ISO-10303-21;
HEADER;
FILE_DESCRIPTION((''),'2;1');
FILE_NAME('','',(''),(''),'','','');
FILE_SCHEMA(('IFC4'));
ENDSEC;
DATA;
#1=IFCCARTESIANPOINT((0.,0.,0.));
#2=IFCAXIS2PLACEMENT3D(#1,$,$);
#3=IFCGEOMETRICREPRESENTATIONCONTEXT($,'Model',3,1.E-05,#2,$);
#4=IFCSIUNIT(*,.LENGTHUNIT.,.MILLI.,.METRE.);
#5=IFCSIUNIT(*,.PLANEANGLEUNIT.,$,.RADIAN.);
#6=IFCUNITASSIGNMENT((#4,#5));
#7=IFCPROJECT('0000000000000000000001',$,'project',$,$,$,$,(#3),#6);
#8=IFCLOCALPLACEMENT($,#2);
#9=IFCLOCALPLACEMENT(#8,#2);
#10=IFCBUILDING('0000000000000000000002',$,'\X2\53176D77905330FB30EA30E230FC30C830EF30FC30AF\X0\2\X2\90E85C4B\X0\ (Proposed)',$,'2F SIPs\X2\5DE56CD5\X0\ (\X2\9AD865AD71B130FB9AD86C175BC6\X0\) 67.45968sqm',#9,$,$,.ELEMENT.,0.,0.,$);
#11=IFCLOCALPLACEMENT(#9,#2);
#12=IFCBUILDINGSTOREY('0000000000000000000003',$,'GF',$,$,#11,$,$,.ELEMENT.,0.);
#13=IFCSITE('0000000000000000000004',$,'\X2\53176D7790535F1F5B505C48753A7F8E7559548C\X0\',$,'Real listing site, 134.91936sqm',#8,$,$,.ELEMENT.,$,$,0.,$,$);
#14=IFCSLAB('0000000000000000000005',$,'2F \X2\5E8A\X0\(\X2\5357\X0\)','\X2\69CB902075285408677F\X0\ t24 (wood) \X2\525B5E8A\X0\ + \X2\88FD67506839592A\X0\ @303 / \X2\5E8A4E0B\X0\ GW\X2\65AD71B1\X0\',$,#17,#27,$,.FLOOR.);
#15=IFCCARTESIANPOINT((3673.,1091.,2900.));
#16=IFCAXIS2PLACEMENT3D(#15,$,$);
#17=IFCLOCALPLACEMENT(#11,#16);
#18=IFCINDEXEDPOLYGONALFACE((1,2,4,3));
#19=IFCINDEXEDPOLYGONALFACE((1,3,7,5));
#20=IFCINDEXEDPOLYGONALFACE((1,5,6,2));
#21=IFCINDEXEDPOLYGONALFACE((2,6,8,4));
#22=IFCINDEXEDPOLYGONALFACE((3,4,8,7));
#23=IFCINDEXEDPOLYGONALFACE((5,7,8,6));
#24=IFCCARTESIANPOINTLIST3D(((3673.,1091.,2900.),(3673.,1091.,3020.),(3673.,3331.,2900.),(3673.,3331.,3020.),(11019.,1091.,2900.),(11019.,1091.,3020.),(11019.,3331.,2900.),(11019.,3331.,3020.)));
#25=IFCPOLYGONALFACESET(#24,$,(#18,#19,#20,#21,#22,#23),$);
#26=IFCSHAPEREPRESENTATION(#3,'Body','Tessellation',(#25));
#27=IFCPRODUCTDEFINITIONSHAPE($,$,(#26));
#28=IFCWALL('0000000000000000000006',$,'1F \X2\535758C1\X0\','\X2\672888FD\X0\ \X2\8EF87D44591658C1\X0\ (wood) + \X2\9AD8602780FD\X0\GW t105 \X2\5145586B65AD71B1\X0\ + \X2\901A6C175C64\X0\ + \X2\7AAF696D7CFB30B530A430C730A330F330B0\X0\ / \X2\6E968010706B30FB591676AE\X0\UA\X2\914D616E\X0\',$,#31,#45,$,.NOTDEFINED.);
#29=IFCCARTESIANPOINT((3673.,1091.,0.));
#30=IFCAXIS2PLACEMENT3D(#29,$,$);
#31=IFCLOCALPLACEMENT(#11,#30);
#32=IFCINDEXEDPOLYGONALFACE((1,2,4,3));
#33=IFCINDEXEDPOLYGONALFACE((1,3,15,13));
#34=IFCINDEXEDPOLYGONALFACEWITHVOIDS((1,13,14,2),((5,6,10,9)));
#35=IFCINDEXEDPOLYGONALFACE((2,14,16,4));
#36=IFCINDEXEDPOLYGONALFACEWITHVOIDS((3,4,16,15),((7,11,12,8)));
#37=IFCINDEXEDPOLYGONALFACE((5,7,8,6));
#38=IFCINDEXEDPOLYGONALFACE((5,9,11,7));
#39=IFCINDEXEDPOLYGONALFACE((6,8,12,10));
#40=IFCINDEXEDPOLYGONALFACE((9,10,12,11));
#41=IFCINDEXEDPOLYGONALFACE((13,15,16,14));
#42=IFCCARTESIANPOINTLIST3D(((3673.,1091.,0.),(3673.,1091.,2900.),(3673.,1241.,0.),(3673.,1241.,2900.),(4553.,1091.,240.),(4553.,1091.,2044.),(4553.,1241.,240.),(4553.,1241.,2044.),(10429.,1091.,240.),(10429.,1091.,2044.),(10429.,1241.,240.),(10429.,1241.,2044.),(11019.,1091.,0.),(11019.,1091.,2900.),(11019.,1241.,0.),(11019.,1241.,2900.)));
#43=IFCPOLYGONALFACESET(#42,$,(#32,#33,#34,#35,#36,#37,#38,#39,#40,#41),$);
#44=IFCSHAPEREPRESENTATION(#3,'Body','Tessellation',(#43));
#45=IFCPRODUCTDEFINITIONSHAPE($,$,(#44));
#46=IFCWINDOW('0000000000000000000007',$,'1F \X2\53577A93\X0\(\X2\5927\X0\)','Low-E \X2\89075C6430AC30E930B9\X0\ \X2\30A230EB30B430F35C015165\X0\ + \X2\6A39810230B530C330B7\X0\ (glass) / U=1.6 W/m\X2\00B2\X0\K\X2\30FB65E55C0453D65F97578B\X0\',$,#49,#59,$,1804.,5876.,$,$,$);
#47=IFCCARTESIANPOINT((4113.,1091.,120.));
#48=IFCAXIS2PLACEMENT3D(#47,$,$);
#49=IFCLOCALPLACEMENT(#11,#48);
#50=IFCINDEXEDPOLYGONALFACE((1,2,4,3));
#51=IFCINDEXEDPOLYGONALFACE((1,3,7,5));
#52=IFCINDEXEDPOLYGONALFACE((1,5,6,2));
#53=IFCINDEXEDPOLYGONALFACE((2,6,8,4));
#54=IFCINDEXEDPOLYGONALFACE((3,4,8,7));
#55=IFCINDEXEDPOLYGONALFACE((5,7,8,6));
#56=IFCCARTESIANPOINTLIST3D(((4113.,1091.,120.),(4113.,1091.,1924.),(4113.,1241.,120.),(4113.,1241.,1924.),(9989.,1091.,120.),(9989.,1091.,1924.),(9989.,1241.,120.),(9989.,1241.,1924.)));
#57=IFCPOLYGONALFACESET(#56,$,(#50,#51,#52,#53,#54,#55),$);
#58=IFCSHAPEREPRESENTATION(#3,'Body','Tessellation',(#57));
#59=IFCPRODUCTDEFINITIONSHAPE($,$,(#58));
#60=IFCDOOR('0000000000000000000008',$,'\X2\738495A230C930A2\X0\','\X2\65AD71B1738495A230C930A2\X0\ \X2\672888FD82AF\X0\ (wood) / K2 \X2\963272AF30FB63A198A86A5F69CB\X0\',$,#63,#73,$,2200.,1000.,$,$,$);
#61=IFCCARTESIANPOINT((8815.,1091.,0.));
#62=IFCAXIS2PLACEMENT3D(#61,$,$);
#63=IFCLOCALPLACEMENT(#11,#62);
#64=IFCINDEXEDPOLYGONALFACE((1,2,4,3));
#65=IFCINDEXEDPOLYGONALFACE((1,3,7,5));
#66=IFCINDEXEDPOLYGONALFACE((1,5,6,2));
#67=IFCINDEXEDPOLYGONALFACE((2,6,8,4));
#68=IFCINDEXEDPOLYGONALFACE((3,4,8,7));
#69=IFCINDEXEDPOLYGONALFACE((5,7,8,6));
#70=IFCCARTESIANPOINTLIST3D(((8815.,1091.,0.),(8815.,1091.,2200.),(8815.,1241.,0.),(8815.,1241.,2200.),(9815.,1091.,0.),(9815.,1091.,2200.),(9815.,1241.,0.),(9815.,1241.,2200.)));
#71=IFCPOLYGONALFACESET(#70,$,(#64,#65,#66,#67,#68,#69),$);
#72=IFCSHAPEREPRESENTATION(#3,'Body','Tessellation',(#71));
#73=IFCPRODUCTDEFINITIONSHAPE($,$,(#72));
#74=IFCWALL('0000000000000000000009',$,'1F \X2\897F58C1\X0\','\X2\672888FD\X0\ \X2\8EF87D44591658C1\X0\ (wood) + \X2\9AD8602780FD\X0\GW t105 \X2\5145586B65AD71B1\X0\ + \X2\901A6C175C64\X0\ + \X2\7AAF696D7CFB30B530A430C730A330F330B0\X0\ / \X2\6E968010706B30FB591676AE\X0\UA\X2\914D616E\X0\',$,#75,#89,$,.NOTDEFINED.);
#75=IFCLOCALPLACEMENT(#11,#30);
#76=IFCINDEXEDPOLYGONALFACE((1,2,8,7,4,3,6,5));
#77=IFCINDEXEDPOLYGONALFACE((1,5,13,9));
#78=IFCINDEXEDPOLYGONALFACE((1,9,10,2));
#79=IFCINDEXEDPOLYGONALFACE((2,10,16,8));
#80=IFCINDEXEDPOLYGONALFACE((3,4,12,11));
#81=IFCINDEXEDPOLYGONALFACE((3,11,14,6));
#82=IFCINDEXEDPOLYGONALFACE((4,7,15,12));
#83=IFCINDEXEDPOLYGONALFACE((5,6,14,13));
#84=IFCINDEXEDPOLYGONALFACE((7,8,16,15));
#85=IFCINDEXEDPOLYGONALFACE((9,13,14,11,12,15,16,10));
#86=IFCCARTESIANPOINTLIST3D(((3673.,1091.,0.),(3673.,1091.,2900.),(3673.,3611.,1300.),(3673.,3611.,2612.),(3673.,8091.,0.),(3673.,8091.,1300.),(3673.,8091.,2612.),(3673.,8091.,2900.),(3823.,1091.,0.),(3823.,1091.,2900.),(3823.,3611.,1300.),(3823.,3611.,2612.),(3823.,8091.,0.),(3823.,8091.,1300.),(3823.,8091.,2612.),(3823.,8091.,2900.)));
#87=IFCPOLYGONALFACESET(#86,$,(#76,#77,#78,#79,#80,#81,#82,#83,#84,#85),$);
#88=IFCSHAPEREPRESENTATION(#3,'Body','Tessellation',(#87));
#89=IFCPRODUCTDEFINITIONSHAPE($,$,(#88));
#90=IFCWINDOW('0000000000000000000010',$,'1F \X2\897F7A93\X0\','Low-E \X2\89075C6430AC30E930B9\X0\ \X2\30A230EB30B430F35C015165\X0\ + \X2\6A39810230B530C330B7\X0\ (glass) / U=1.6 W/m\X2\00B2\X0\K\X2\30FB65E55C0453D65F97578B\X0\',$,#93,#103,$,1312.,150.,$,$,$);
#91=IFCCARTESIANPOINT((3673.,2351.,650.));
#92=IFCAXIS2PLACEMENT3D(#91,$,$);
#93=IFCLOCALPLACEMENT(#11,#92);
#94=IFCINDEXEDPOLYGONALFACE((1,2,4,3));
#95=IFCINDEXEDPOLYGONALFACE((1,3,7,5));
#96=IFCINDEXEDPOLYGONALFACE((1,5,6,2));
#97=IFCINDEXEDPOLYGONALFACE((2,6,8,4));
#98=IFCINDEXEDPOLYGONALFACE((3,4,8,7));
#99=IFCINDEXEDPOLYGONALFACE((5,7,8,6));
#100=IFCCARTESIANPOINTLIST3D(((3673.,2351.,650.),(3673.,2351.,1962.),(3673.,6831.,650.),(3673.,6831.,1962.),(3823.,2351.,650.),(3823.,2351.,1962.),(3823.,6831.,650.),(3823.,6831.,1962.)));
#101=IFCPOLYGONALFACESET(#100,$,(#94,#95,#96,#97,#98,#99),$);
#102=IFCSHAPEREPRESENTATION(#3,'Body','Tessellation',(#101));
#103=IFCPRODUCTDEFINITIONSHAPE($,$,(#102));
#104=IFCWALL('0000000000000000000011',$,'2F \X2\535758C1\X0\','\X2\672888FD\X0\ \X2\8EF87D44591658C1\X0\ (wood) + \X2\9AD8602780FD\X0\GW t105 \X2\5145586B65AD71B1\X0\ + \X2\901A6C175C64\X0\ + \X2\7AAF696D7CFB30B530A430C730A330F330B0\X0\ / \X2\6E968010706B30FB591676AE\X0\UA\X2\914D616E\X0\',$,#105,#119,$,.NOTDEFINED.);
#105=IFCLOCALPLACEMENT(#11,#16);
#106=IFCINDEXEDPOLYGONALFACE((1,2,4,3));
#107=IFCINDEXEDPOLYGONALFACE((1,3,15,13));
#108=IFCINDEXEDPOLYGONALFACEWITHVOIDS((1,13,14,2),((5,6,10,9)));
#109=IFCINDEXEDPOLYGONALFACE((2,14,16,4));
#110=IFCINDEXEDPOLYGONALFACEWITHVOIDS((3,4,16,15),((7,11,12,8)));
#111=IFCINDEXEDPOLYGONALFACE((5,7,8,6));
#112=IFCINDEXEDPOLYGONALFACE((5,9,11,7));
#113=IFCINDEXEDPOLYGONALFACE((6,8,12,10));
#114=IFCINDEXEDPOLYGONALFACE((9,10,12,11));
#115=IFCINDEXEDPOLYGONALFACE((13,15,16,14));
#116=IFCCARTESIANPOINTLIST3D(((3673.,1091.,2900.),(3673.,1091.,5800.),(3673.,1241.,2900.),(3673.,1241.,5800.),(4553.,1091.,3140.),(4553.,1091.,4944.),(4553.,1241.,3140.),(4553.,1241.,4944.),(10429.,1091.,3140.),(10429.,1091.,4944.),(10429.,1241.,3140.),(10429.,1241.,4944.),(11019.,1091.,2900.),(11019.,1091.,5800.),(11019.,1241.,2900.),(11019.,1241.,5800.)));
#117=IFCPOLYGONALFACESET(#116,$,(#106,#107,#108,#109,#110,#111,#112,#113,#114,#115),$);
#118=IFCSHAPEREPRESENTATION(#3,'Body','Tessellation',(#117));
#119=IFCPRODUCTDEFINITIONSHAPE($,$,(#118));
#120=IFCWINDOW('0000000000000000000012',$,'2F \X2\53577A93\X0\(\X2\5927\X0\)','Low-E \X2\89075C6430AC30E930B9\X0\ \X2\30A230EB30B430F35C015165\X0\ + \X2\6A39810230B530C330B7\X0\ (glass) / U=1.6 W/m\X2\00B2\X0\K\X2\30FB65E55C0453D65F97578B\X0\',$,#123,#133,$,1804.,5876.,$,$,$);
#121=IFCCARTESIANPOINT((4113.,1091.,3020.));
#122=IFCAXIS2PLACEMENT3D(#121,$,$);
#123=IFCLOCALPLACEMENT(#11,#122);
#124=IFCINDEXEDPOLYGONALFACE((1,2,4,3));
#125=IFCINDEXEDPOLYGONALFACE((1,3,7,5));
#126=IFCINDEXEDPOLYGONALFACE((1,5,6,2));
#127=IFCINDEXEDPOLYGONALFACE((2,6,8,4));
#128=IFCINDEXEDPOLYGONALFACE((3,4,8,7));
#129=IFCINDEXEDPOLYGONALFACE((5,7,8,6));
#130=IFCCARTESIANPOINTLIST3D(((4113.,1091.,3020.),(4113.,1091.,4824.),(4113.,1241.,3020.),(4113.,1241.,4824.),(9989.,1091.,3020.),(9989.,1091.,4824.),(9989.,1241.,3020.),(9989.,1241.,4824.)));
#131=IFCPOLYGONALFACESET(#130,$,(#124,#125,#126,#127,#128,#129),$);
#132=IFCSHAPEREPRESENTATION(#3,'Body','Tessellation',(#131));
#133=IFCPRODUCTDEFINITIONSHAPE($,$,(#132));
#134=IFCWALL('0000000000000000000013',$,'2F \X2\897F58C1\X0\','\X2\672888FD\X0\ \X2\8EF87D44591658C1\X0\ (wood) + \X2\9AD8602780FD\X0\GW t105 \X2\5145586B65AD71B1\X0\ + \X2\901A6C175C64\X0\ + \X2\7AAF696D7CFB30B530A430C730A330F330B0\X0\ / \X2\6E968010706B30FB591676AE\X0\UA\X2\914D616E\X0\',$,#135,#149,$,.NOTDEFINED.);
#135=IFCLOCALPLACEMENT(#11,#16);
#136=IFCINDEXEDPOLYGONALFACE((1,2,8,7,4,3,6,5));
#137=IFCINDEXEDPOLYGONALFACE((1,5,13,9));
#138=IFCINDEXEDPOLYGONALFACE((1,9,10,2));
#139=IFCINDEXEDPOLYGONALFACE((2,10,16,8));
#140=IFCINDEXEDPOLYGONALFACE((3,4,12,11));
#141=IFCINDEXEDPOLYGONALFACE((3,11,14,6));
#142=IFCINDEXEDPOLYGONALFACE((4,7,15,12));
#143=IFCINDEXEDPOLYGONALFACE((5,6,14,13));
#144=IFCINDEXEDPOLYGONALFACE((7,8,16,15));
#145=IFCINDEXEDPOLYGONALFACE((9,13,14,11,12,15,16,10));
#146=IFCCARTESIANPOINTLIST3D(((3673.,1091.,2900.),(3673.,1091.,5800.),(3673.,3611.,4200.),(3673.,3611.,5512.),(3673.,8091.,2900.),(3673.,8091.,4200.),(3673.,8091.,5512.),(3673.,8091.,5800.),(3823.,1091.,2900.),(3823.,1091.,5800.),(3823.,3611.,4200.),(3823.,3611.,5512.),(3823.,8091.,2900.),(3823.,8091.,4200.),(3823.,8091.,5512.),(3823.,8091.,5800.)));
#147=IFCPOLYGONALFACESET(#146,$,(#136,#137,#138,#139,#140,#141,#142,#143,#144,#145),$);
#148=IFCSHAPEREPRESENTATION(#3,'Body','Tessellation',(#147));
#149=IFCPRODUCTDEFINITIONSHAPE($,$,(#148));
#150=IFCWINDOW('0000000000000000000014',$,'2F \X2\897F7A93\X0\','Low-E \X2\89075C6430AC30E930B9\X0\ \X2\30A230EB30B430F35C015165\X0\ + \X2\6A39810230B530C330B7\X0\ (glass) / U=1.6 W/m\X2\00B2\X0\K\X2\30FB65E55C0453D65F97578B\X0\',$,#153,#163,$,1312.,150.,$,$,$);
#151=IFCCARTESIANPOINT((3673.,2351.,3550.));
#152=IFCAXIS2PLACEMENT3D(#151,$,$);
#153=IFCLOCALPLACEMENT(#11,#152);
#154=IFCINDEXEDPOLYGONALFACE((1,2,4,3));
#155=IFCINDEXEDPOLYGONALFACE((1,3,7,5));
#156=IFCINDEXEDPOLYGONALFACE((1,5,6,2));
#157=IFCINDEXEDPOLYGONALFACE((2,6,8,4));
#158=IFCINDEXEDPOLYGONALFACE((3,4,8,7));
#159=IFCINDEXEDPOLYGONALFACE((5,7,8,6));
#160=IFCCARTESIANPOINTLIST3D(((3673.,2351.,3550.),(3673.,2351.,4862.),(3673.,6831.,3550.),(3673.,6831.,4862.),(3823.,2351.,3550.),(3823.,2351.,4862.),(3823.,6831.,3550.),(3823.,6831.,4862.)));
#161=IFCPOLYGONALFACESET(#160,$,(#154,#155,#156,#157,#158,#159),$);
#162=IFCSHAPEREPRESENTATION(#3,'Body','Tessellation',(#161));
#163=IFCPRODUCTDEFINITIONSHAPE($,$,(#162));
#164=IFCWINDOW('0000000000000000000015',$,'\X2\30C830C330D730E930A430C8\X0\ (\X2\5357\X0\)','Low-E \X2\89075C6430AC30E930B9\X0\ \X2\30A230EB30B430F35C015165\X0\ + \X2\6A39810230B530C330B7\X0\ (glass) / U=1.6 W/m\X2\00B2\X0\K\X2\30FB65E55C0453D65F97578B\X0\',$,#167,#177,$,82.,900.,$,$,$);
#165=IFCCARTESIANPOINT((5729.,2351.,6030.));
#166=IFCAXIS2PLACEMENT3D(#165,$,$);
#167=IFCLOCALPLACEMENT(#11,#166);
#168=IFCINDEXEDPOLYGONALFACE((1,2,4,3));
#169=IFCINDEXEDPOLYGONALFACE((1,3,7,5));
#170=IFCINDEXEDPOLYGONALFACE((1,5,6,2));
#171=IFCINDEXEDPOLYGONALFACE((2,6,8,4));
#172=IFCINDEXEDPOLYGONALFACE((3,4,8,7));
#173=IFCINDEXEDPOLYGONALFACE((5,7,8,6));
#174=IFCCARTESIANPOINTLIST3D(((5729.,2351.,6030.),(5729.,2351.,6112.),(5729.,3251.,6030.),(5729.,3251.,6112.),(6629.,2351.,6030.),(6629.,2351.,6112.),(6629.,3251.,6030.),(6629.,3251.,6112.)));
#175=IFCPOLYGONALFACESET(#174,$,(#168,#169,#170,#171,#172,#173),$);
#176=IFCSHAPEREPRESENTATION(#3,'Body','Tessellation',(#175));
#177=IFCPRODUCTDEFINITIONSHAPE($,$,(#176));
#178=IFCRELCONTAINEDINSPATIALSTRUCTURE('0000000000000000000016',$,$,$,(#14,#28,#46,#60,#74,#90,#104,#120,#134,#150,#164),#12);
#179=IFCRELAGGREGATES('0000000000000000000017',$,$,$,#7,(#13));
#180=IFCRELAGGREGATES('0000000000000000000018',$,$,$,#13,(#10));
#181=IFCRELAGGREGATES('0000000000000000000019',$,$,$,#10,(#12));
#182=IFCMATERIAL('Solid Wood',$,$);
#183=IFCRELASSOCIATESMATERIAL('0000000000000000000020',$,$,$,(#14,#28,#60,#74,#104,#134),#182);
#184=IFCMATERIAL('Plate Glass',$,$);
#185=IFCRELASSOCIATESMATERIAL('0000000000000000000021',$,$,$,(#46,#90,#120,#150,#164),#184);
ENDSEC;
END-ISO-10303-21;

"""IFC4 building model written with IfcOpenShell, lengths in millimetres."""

from ifc_helpers import new_model, si_unit, frame, frame_2d, origin, place, context, project, spatial, rectangle, extrude, material, element, fill, save


model = new_model("IFC4")

# Units and contexts
model_context = context("Model", 3, precision=1e-05, world=origin())
ifc_project = project(units=[si_unit("LENGTHUNIT", "METRE", prefix="MILLI"), si_unit("PLANEANGLEUNIT", "RADIAN")], contexts=[model_context])

# Site, building, storey
site_placement = place(None, origin())
site = spatial("IfcSite", under=ifc_project, at=site_placement, Name="北海道弟子屈町美留和", ObjectType="Real listing site, 134.91936sqm", CompositionType="ELEMENT", RefElevation=0.0)
building_placement = place(site_placement, origin())
building = spatial("IfcBuilding", under=site, at=building_placement, Name="北海道・リモートワーク2部屋 (Proposed)", ObjectType="2F SIPs工法 (高断熱・高気密) 67.45968sqm", CompositionType="ELEMENT", ElevationOfRefHeight=0.0, ElevationOfTerrain=0.0)
storey_placement = place(building_placement, origin())
storey = spatial("IfcBuildingStorey", under=building, at=storey_placement, Name="GF", CompositionType="ELEMENT", Elevation=0.0)

# Slab
ifc_material_1 = material(Name="Solid Wood")
slab_1_placement = place(storey_placement, frame((3673.0, 1091.0, 2900.0)))
element("IfcSlab", 1, at=slab_1_placement, inside=storey, material=ifc_material_1, Name="2F 床(南)", Description="構造用合板 t24 (wood) 剛床 + 製材根太 @303 / 床下 GW断熱", PredefinedType="FLOOR", context=model_context, shape_type="SweptSolid", body=[
    extrude(rectangle(XDim=7346.0, YDim=2240.0, at=frame_2d((3673.0, 1120.0))), frame((3673.0, 1091.0, 2900.0)), (0.0, 0.0, 1.0), 120.0),
])

# Wall, openings, window, door
wall_1_placement = place(storey_placement, frame((3673.0, 1091.0, 0.0)))
wall_1 = element("IfcWall", 2, at=wall_1_placement, inside=storey, material=ifc_material_1, Name="1F 南壁", Description="木製 軸組外壁 (wood) + 高性能GW t105 充填断熱 + 通気層 + 窯業系サイディング / 準耐火・外皮UA配慮", PredefinedType="NOTDEFINED", context=model_context, shape_type="SweptSolid", body=[
    extrude(rectangle(XDim=7346.0, YDim=150.0, at=frame_2d((3673.0, 75.0))), frame((3673.0, 1091.0, 0.0)), (0.0, 0.0, 1.0), 2900.0),
])
opening_1_placement = place(storey_placement, frame((4113.0, 1091.0, 120.0)))
opening_1 = element("IfcOpeningElement", 3, at=opening_1_placement, cuts=wall_1, PredefinedType="NOTDEFINED", context=model_context, shape_type="SweptSolid", body=[
    extrude(rectangle(XDim=5876.0, YDim=150.0, at=frame_2d((2938.0, 75.0))), frame((4113.0, 1091.0, 120.0)), (0.0, 0.0, 1.0), 1804.0),
])
opening_2_placement = place(storey_placement, frame((8815.0, 1091.0, 0.0)))
opening_2 = element("IfcOpeningElement", 4, at=opening_2_placement, cuts=wall_1, PredefinedType="NOTDEFINED", context=model_context, shape_type="SweptSolid", body=[
    extrude(rectangle(XDim=1000.0, YDim=150.0, at=frame_2d((500.0, 75.0))), frame((8815.0, 1091.0, 0.0)), (0.0, 0.0, 1.0), 2200.0),
])
ifc_material_2 = material(Name="Plate Glass")
window_1_placement = place(storey_placement, frame((4113.0, 1091.0, 120.0)))
window_1 = element("IfcWindow", 5, at=window_1_placement, inside=storey, material=ifc_material_2, Name="1F 南窓(大)", Description="Low-E 複層ガラス アルゴン封入 + 樹脂サッシ (glass) / U=1.6 W/m²K・日射取得型", OverallHeight=1804.0, OverallWidth=5876.0, context=model_context, shape_type="SweptSolid", body=[
    extrude(rectangle(XDim=5876.0, YDim=150.0, at=frame_2d((2938.0, 75.0))), frame((4113.0, 1091.0, 120.0)), (0.0, 0.0, 1.0), 1804.0),
])
fill(opening_1, window_1)
door_placement = place(storey_placement, frame((8815.0, 1091.0, 0.0)))
door = element("IfcDoor", 6, at=door_placement, inside=storey, material=ifc_material_1, Name="玄関ドア", Description="断熱玄関ドア 木製芯 (wood) / K2 防犯・採風機構", OverallHeight=2200.0, OverallWidth=1000.0, context=model_context, shape_type="SweptSolid", body=[
    extrude(rectangle(XDim=1000.0, YDim=150.0, at=frame_2d((500.0, 75.0))), frame((8815.0, 1091.0, 0.0)), (0.0, 0.0, 1.0), 2200.0),
])
fill(opening_2, door)

# Walls, openings, windows
wall_2_placement = place(storey_placement, frame((3673.0, 1091.0, 0.0)))
wall_2 = element("IfcWall", 7, at=wall_2_placement, inside=storey, material=ifc_material_1, Name="1F 西壁", Description="木製 軸組外壁 (wood) + 高性能GW t105 充填断熱 + 通気層 + 窯業系サイディング / 準耐火・外皮UA配慮", PredefinedType="NOTDEFINED", context=model_context, shape_type="SweptSolid", body=[
    extrude(rectangle(XDim=150.0, YDim=7000.0, at=frame_2d((75.0, 3500.0))), frame((3673.0, 1091.0, 0.0)), (0.0, 0.0, 1.0), 2900.0),
])
opening_3_placement = place(storey_placement, frame((3673.0, 2351.0, 650.0)))
opening_3 = element("IfcOpeningElement", 8, at=opening_3_placement, cuts=wall_2, PredefinedType="NOTDEFINED", context=model_context, shape_type="SweptSolid", body=[
    extrude(rectangle(XDim=150.0, YDim=4480.0, at=frame_2d((75.0, 2240.0))), frame((3673.0, 2351.0, 650.0)), (0.0, 0.0, 1.0), 1312.0),
])
window_2_placement = place(storey_placement, frame((3673.0, 2351.0, 650.0)))
window_2 = element("IfcWindow", 9, at=window_2_placement, inside=storey, material=ifc_material_2, Name="1F 西窓", Description="Low-E 複層ガラス アルゴン封入 + 樹脂サッシ (glass) / U=1.6 W/m²K・日射取得型", OverallHeight=1312.0, OverallWidth=150.0, context=model_context, shape_type="SweptSolid", body=[
    extrude(rectangle(XDim=150.0, YDim=4480.0, at=frame_2d((75.0, 2240.0))), frame((3673.0, 2351.0, 650.0)), (0.0, 0.0, 1.0), 1312.0),
])
fill(opening_3, window_2)
wall_3_placement = place(storey_placement, frame((3673.0, 1091.0, 2900.0)))
wall_3 = element("IfcWall", 10, at=wall_3_placement, inside=storey, material=ifc_material_1, Name="2F 南壁", Description="木製 軸組外壁 (wood) + 高性能GW t105 充填断熱 + 通気層 + 窯業系サイディング / 準耐火・外皮UA配慮", PredefinedType="NOTDEFINED", context=model_context, shape_type="SweptSolid", body=[
    extrude(rectangle(XDim=7346.0, YDim=150.0, at=frame_2d((3673.0, 75.0))), frame((3673.0, 1091.0, 2900.0)), (0.0, 0.0, 1.0), 2900.0),
])
opening_4_placement = place(storey_placement, frame((4113.0, 1091.0, 3020.0)))
opening_4 = element("IfcOpeningElement", 11, at=opening_4_placement, cuts=wall_3, PredefinedType="NOTDEFINED", context=model_context, shape_type="SweptSolid", body=[
    extrude(rectangle(XDim=5876.0, YDim=150.0, at=frame_2d((2938.0, 75.0))), frame((4113.0, 1091.0, 3020.0)), (0.0, 0.0, 1.0), 1804.0),
])
window_3_placement = place(storey_placement, frame((4113.0, 1091.0, 3020.0)))
window_3 = element("IfcWindow", 12, at=window_3_placement, inside=storey, material=ifc_material_2, Name="2F 南窓(大)", Description="Low-E 複層ガラス アルゴン封入 + 樹脂サッシ (glass) / U=1.6 W/m²K・日射取得型", OverallHeight=1804.0, OverallWidth=5876.0, context=model_context, shape_type="SweptSolid", body=[
    extrude(rectangle(XDim=5876.0, YDim=150.0, at=frame_2d((2938.0, 75.0))), frame((4113.0, 1091.0, 3020.0)), (0.0, 0.0, 1.0), 1804.0),
])
fill(opening_4, window_3)
wall_4_placement = place(storey_placement, frame((3673.0, 1091.0, 2900.0)))
wall_4 = element("IfcWall", 13, at=wall_4_placement, inside=storey, material=ifc_material_1, Name="2F 西壁", Description="木製 軸組外壁 (wood) + 高性能GW t105 充填断熱 + 通気層 + 窯業系サイディング / 準耐火・外皮UA配慮", PredefinedType="NOTDEFINED", context=model_context, shape_type="SweptSolid", body=[
    extrude(rectangle(XDim=150.0, YDim=7000.0, at=frame_2d((75.0, 3500.0))), frame((3673.0, 1091.0, 2900.0)), (0.0, 0.0, 1.0), 2900.0),
])
opening_5_placement = place(storey_placement, frame((3673.0, 2351.0, 3550.0)))
opening_5 = element("IfcOpeningElement", 14, at=opening_5_placement, cuts=wall_4, PredefinedType="NOTDEFINED", context=model_context, shape_type="SweptSolid", body=[
    extrude(rectangle(XDim=150.0, YDim=4480.0, at=frame_2d((75.0, 2240.0))), frame((3673.0, 2351.0, 3550.0)), (0.0, 0.0, 1.0), 1312.0),
])
window_4_placement = place(storey_placement, frame((3673.0, 2351.0, 3550.0)))
window_4 = element("IfcWindow", 15, at=window_4_placement, inside=storey, material=ifc_material_2, Name="2F 西窓", Description="Low-E 複層ガラス アルゴン封入 + 樹脂サッシ (glass) / U=1.6 W/m²K・日射取得型", OverallHeight=1312.0, OverallWidth=150.0, context=model_context, shape_type="SweptSolid", body=[
    extrude(rectangle(XDim=150.0, YDim=4480.0, at=frame_2d((75.0, 2240.0))), frame((3673.0, 2351.0, 3550.0)), (0.0, 0.0, 1.0), 1312.0),
])
fill(opening_5, window_4)

# Window
window_5_placement = place(storey_placement, frame((5729.0, 2351.0, 6030.0)))
element("IfcWindow", 16, at=window_5_placement, inside=storey, material=ifc_material_2, Name="トップライト (南)", Description="Low-E 複層ガラス アルゴン封入 + 樹脂サッシ (glass) / U=1.6 W/m²K・日射取得型", OverallHeight=82.0, OverallWidth=900.0, context=model_context, shape_type="SweptSolid", body=[
    extrude(rectangle(XDim=900.0, YDim=900.0, at=frame_2d((450.0, 450.0))), frame((5729.0, 2351.0, 6030.0)), (0.0, 0.0, 1.0), 82.0),
])

save(model, "model.ifc")
